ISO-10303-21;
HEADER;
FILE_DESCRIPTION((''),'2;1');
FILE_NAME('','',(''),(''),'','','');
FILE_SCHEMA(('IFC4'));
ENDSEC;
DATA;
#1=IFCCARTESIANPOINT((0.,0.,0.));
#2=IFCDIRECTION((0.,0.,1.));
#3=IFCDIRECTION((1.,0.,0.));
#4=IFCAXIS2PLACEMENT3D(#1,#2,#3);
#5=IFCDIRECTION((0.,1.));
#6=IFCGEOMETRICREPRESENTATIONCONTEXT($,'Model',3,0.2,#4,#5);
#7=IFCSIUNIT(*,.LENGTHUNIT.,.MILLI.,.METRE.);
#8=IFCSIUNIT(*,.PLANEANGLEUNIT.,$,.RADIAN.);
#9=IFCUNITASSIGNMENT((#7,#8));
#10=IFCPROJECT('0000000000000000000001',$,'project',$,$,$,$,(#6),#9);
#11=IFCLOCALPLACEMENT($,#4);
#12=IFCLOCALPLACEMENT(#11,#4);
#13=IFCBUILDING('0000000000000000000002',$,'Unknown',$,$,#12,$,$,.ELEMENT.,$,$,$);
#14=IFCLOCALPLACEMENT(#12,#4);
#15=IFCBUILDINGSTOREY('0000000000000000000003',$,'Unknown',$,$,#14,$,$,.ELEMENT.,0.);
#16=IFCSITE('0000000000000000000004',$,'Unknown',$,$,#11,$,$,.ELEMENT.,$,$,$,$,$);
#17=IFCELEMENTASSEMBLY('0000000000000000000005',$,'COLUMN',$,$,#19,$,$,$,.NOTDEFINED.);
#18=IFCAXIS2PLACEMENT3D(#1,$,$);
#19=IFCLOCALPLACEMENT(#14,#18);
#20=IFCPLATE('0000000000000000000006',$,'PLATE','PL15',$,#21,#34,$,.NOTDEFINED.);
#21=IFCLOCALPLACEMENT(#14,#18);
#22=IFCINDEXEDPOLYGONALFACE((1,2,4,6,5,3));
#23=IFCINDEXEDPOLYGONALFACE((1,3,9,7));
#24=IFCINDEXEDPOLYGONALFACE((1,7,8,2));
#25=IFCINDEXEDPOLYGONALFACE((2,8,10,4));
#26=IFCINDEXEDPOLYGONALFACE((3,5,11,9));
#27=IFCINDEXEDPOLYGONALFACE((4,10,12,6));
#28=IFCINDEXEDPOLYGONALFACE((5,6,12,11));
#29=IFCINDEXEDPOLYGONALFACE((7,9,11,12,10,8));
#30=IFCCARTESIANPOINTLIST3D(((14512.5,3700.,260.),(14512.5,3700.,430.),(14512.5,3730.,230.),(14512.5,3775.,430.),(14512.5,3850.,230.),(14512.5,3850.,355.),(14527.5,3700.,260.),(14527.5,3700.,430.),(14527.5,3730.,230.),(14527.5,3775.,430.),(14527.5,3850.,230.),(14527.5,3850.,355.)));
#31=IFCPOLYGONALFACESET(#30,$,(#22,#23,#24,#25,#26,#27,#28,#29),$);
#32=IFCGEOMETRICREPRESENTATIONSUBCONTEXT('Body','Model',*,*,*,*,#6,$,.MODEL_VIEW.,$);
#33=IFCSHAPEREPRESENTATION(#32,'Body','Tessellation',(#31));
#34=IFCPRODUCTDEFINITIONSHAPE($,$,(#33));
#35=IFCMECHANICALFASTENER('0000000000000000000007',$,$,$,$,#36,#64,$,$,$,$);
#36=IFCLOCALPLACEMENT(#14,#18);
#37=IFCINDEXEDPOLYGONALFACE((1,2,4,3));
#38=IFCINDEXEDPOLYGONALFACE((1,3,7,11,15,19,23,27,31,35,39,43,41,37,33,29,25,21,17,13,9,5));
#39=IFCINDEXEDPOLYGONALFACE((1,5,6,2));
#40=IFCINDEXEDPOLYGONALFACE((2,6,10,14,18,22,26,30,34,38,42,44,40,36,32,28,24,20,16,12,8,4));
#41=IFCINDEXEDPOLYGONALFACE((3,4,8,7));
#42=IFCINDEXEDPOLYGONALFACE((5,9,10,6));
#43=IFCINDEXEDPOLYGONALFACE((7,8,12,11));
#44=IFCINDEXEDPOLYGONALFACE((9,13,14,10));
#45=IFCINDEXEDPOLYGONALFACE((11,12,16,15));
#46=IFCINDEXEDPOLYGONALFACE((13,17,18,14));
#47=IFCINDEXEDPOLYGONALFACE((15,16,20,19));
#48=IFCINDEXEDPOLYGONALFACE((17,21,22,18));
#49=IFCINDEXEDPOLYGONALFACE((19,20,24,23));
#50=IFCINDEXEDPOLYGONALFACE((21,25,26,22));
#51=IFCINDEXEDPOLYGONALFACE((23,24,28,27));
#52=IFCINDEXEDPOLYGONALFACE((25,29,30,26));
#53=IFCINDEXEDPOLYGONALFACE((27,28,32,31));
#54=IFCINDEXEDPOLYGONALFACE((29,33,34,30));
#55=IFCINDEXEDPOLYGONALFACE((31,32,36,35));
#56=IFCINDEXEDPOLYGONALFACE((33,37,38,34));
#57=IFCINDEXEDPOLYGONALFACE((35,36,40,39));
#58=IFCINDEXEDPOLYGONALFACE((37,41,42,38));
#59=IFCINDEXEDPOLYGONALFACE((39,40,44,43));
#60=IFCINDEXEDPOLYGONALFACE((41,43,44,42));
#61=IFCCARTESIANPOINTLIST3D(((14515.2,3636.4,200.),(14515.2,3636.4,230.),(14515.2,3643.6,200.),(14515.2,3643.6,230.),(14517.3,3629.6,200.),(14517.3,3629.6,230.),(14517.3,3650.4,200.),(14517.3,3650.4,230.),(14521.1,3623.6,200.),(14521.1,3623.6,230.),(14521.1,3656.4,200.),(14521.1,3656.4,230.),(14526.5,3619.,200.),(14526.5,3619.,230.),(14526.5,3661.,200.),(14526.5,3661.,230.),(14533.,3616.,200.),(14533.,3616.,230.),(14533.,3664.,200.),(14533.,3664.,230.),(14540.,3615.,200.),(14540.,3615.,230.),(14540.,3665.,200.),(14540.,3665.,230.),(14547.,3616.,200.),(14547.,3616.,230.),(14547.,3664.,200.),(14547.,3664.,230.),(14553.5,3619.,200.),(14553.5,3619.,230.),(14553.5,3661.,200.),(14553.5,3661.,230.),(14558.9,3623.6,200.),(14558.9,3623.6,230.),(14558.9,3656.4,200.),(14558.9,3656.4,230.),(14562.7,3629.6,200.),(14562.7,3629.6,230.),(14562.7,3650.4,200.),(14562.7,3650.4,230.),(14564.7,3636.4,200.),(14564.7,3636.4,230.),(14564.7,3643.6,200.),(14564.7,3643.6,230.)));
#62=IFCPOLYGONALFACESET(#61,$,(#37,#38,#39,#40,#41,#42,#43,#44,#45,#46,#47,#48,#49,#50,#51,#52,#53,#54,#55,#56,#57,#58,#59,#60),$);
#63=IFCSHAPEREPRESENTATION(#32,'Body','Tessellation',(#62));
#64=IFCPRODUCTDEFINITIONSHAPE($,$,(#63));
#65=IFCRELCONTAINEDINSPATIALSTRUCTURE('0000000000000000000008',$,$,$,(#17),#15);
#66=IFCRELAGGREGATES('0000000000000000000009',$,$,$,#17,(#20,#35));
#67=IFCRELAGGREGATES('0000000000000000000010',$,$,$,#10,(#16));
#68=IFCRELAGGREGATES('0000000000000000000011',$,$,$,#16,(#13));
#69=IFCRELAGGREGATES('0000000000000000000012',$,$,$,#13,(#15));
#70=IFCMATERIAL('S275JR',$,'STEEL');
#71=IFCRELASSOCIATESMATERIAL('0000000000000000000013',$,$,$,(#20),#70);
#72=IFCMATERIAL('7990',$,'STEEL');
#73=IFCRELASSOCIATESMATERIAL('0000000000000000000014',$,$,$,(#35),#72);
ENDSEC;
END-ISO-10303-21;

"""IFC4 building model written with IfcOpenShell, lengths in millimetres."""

from ifc_helpers import new_model, si_unit, direction, frame, origin_with_axes, place, context, subcontext, project, spatial, line, arc, indexed_curve, outline, extrude, source, transform, mapped, material, element, aggregate, save


model = new_model("IFC4")

# Units and contexts
model_context = context("Model", 3, precision=0.2, world=origin_with_axes(), true_north=direction((0.0, 1.0)))
body_context = subcontext(model_context, "Body", "Model", "MODEL_VIEW")
ifc_project = project(units=[si_unit("LENGTHUNIT", "METRE", prefix="MILLI"), si_unit("PLANEANGLEUNIT", "RADIAN")], contexts=[model_context])

# Site, building, storey
site_placement = place(None, origin_with_axes())
site = spatial("IfcSite", under=ifc_project, at=site_placement, Name="Unknown", CompositionType="ELEMENT")
building_placement = place(site_placement, origin_with_axes())
building = spatial("IfcBuilding", under=site, at=building_placement, Name="Unknown", CompositionType="ELEMENT")
storey_placement = place(building_placement, origin_with_axes())
storey = spatial("IfcBuildingStorey", under=building, at=storey_placement, Name="Unknown", CompositionType="ELEMENT", Elevation=0.0)

# Shared definitions
ifc_material_1 = material(Name="S275JR", Category="STEEL")

# Element assembly, plate, mechanical fastener
assembly_1_placement = place(storey_placement, frame((14600.0, 3600.0, 200.0), z_axis=(-1.0, 0.0, 0.0), x_axis=(0.0, 0.0, 1.0)))
assembly_1 = element("IfcElementAssembly", 1, at=assembly_1_placement, inside=storey, Name="COLUMN", PredefinedType="NOTDEFINED")
plate_1_placement = place(assembly_1_placement, frame((60.0, 100.0, 80.0), z_axis=(0.0, -0.000002, -1.0), x_axis=(-0.707113, 0.707101, 0.0)))
plate_1 = element("IfcPlate", 2, at=plate_1_placement, material=ifc_material_1, Name="PLATE", Description="PL15", PredefinedType="NOTDEFINED", context=body_context, shape_type="SolidModel", body=[
    extrude(outline(indexed_curve([(0.0, 0.0), (42.4, 0.0), (127.3, 84.9), (38.9, 173.2), (-67.2, 173.2), (-120.2, 120.2)], segments=[line(1, 2, 3, 4, 5, 6, 1)])), frame((0.0, 0.0, 7.5), z_axis=(0.0, 0.0, 1.0), x_axis=(1.0, 0.0, 0.0)), (0.0, -0.000002, -1.0), 15.0),
])
ifc_material_2 = material(Name="7990", Category="STEEL")
shared_shape_1 = source(origin_with_axes(), body_context, "Body", "SweptSolid", [
    extrude(outline(indexed_curve([(25.0, 0.0), (0.0, 25.0), (-25.0, 0.0), (0.0, -25.0)], segments=[arc(1, 2, 3), arc(3, 4, 1)])), frame((0.0, 0.0, 0.0), z_axis=(0.0, -0.000002, -1.0), x_axis=(0.0, 1.0, 0.0)), (0.0, 0.0, 1.0), 30.0),
])
mechanical_fastener_1_placement = place(assembly_1_placement, frame((30.0, 40.0, 60.0), z_axis=(1.0, 0.0, 0.0), x_axis=(0.0, -0.000002, -1.0)))
mechanical_fastener_1 = element("IfcMechanicalFastener", 3, at=mechanical_fastener_1_placement, material=ifc_material_2, context=body_context, shape_type="MappedRepresentation", body=[
    mapped(shared_shape_1, transform((0.0, 0.0, 0.0))),
])

aggregate(assembly_1, [plate_1, mechanical_fastener_1])

save(model, "model.ifc")
